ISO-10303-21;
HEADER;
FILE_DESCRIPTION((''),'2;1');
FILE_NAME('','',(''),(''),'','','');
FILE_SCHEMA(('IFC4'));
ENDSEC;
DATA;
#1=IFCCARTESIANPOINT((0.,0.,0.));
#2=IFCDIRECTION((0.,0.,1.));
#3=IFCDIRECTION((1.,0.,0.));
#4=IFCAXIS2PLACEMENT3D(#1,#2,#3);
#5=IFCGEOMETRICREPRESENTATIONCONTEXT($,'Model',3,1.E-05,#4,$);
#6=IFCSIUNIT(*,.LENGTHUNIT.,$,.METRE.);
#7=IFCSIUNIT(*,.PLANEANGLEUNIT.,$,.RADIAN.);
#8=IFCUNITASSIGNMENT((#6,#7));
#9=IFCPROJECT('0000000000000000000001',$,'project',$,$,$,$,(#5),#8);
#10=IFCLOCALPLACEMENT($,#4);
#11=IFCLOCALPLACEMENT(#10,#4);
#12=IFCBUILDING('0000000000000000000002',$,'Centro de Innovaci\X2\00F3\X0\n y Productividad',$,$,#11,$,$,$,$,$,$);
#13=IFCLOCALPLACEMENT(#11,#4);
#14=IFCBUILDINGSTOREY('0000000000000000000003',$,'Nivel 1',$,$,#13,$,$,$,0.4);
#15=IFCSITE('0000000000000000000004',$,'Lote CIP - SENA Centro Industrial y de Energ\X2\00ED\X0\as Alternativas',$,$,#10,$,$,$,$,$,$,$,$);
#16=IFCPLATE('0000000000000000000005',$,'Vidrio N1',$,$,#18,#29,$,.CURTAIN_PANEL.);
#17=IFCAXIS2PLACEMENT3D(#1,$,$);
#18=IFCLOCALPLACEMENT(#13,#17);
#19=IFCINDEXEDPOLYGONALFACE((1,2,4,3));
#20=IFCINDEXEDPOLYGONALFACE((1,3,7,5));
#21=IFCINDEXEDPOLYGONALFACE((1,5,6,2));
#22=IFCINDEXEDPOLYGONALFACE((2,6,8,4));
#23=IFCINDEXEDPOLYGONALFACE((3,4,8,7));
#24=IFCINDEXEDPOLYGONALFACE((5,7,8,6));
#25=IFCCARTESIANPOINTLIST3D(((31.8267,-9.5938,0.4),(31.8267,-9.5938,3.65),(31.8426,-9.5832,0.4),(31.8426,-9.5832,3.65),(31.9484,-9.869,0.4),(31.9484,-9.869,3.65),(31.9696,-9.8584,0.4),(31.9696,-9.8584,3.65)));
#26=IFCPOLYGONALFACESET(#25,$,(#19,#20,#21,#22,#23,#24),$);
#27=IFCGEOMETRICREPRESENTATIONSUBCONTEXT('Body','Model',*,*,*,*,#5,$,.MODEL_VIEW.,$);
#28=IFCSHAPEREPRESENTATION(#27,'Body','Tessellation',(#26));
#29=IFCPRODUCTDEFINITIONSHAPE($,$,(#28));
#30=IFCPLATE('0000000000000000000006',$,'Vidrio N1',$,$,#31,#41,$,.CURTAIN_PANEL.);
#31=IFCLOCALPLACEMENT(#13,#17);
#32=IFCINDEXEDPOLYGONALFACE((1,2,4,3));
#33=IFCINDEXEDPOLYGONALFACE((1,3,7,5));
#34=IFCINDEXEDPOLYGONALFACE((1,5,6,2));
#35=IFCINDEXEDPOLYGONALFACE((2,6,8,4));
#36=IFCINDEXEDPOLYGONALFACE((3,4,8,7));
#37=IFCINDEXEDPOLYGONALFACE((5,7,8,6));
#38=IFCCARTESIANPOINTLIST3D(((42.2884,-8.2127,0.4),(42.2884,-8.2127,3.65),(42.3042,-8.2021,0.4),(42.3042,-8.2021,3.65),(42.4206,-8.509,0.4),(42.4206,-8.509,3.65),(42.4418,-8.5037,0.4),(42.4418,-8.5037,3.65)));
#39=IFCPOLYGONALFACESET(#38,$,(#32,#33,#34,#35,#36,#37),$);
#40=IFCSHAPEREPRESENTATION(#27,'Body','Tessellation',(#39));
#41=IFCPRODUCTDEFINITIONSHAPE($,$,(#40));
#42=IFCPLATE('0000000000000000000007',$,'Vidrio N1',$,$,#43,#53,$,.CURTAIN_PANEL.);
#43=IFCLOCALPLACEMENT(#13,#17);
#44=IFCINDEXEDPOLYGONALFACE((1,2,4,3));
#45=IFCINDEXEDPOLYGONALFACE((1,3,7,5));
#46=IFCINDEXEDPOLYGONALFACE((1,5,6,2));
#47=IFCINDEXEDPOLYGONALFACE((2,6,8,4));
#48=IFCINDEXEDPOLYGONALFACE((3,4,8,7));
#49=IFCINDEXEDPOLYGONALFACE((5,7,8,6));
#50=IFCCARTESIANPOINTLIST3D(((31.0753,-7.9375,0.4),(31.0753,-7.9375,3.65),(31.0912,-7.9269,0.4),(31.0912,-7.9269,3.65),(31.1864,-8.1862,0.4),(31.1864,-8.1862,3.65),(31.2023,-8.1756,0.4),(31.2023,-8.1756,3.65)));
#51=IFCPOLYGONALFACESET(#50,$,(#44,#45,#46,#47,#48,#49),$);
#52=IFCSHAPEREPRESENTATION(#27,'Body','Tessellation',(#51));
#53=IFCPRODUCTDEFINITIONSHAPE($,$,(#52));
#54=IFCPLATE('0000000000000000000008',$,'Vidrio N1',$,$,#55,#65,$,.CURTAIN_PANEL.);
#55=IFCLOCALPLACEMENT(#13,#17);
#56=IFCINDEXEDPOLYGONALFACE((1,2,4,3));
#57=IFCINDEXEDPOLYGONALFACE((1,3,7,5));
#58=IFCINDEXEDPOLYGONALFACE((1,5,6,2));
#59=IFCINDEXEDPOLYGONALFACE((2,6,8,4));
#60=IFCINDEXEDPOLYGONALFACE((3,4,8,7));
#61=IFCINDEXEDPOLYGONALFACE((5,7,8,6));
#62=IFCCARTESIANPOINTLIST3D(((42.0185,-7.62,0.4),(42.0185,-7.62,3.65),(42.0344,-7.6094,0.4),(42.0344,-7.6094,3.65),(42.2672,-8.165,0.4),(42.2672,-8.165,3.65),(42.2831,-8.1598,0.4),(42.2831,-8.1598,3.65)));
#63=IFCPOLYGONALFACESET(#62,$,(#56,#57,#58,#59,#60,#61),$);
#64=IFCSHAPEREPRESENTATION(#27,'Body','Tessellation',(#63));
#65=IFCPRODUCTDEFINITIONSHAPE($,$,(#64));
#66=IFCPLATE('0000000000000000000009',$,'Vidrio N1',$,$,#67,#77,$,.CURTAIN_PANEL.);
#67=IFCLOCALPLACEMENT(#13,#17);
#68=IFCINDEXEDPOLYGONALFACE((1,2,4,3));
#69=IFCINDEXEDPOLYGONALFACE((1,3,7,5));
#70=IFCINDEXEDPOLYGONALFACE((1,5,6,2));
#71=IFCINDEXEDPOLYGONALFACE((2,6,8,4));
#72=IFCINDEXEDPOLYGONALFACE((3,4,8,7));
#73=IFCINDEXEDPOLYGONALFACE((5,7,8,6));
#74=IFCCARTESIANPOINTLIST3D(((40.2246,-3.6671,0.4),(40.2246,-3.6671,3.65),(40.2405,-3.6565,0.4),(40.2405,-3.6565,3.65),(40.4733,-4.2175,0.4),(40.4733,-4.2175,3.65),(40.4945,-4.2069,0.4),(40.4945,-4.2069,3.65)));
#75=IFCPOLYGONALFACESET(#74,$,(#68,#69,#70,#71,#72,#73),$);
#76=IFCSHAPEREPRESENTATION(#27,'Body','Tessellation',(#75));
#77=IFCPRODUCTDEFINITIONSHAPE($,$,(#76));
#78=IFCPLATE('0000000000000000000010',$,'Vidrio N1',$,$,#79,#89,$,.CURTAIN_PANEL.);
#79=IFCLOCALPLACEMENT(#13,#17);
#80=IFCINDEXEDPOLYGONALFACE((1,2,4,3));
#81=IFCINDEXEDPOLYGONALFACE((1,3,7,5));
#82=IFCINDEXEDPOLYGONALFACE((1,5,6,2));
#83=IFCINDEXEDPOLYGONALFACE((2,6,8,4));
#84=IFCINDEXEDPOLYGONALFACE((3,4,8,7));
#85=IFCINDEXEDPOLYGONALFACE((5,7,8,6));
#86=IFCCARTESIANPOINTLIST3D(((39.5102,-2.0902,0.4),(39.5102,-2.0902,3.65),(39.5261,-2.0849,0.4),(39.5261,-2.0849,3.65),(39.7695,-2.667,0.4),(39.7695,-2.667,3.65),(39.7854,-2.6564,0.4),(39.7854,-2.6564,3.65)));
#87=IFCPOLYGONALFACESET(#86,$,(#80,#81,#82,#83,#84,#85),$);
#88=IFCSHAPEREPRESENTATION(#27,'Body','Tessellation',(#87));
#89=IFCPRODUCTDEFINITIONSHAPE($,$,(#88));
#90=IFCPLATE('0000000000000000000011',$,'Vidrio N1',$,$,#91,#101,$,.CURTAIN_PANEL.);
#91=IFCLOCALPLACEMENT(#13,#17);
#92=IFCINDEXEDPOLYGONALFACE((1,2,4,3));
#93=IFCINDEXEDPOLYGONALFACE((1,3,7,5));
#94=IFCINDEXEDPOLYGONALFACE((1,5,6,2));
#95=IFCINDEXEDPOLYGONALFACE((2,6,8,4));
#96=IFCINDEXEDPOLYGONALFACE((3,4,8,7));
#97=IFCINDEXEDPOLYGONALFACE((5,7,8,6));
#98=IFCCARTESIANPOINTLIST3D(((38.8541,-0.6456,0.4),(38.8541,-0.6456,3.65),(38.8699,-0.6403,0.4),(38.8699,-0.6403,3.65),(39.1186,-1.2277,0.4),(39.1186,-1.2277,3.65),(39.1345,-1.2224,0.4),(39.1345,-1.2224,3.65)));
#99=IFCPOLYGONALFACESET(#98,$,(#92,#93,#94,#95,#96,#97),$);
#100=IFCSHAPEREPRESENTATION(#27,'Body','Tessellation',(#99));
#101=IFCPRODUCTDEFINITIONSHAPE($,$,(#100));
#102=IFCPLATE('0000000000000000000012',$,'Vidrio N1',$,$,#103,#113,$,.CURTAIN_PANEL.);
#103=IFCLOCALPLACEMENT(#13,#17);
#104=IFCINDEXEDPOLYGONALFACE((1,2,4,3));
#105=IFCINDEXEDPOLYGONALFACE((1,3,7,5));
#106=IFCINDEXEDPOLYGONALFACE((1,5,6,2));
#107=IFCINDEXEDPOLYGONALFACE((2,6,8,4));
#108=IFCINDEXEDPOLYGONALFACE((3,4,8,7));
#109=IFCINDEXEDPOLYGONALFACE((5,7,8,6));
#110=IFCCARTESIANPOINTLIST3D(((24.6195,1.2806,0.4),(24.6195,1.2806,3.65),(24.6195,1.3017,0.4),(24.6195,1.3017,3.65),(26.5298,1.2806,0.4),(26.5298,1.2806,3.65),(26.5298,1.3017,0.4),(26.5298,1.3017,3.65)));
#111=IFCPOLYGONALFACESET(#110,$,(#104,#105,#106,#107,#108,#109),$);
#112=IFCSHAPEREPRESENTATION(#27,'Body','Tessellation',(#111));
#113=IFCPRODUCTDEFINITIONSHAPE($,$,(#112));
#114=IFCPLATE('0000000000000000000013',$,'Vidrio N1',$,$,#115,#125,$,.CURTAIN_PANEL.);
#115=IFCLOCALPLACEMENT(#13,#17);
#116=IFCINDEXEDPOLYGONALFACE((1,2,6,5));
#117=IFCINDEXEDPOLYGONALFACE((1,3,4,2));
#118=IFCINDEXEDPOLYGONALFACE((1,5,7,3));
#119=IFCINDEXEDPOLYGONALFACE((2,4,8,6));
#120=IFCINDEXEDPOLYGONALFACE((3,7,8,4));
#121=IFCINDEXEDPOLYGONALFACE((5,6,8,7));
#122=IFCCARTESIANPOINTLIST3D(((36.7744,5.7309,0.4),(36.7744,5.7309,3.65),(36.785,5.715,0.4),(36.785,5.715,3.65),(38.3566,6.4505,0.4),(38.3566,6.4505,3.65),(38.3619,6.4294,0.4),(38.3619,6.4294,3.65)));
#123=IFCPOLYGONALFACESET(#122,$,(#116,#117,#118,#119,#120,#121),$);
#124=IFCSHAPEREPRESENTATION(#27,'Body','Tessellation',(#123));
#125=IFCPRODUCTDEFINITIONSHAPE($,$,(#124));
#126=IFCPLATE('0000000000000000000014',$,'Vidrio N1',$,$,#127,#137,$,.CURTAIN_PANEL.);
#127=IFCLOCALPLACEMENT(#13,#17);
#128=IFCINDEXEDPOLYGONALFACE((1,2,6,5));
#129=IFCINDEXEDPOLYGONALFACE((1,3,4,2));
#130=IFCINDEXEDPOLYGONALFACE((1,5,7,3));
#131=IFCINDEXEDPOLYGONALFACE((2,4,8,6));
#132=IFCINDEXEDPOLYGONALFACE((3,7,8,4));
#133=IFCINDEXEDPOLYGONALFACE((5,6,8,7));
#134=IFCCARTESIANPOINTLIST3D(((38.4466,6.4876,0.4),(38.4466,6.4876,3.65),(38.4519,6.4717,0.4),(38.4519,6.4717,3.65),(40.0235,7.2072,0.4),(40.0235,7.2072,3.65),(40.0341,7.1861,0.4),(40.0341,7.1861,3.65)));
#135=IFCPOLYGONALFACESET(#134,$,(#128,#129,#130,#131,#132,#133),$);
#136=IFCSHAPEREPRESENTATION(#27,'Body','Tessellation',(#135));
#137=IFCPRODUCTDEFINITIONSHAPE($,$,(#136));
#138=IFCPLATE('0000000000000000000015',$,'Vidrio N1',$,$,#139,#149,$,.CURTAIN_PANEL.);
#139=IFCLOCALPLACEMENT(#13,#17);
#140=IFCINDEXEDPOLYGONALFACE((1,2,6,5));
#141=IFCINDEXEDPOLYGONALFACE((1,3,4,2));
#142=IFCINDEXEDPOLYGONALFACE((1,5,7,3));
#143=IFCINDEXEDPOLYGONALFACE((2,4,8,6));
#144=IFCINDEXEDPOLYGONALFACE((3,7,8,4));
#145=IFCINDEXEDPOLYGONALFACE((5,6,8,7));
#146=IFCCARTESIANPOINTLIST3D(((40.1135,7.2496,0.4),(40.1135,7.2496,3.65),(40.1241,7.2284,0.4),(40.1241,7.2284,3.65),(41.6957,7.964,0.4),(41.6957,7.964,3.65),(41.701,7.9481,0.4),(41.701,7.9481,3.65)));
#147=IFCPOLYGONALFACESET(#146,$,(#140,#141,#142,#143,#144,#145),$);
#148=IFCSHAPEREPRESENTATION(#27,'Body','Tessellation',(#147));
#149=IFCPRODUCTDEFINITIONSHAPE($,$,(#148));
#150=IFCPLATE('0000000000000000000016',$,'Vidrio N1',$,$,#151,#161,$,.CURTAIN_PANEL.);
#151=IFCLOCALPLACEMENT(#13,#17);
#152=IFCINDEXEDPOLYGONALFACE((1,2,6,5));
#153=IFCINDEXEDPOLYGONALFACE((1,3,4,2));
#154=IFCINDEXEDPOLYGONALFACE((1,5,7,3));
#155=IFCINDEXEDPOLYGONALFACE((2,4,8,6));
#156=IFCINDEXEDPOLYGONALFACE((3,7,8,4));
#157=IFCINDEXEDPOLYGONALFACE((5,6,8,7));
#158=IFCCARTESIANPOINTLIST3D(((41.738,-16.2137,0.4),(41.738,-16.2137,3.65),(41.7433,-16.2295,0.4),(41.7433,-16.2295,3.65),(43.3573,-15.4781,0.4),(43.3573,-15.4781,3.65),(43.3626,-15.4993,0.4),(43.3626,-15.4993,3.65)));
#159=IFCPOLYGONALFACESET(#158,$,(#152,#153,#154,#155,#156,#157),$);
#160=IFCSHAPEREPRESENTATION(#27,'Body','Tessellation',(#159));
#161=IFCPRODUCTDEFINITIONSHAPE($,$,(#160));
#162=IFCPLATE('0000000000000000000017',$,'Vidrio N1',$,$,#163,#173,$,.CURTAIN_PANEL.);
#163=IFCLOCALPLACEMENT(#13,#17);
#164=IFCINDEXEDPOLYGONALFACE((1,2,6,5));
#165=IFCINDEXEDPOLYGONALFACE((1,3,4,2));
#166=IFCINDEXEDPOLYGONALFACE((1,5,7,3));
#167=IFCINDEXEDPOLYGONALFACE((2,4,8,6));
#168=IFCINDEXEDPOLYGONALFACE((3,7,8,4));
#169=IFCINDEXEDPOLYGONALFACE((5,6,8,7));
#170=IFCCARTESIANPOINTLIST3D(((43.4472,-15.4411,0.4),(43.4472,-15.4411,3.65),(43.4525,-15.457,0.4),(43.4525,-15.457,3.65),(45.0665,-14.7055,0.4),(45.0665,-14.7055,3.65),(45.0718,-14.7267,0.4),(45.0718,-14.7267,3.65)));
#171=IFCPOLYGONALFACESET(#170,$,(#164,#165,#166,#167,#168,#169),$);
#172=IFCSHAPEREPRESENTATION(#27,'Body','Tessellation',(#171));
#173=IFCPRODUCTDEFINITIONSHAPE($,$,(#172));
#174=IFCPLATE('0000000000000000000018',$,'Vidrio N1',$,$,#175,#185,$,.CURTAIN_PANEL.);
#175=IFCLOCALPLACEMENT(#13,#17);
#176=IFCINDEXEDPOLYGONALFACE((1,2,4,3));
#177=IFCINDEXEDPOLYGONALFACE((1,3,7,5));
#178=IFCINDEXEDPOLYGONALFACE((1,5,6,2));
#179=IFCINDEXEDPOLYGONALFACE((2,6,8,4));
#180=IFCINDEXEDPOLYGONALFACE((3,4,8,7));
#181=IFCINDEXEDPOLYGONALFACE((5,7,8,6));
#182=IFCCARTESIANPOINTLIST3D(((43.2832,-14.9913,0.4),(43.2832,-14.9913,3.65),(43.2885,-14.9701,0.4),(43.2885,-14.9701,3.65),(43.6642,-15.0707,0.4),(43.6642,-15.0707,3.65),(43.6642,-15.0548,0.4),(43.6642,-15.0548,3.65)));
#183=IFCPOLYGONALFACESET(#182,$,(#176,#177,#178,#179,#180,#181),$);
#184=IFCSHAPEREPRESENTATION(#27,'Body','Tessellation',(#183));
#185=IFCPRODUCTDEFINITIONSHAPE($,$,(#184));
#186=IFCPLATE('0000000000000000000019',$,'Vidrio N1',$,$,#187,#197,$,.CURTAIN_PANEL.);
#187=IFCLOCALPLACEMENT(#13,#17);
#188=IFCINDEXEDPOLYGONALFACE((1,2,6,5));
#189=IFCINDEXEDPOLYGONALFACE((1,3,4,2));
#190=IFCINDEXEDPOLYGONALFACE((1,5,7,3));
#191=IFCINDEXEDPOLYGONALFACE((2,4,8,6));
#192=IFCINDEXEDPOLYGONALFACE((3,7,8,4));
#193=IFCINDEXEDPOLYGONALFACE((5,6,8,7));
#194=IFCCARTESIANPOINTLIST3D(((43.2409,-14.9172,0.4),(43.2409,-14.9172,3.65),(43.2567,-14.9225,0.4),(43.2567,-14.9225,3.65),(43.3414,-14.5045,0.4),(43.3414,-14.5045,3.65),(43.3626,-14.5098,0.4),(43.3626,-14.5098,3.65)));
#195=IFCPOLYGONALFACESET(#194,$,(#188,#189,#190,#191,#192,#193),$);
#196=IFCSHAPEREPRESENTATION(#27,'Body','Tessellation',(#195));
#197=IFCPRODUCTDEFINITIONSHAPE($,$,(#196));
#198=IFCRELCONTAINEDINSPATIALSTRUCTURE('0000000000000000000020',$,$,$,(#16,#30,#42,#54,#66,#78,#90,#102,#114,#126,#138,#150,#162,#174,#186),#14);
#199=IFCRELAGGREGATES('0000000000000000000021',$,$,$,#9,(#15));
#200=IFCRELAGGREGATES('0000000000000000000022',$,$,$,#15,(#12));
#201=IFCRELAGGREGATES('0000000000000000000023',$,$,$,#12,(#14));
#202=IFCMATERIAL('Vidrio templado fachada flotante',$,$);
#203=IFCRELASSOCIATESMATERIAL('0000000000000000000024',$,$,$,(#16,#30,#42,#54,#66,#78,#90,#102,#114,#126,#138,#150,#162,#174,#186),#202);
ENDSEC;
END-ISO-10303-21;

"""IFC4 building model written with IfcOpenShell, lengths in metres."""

from ifc_helpers import new_model, si_unit, frame, origin_with_axes, place, context, subcontext, project, spatial, polyline, outline, extrude, material, element, save


model = new_model("IFC4")

# Units and contexts
model_context = context("Model", 3, precision=1e-05, world=origin_with_axes())
body_context = subcontext(model_context, "Body", "Model", "MODEL_VIEW")
ifc_project = project(units=[si_unit("LENGTHUNIT", "METRE"), si_unit("PLANEANGLEUNIT", "RADIAN")], contexts=[model_context])

# Site, building, storey
site_placement = place(None, origin_with_axes())
site = spatial("IfcSite", under=ifc_project, at=site_placement, Name="Lote CIP - SENA Centro Industrial y de Energías Alternativas")
building_placement = place(site_placement, origin_with_axes())
building = spatial("IfcBuilding", under=site, at=building_placement, Name="Centro de Innovación y Productividad")
storey_placement = place(building_placement, origin_with_axes())
storey = spatial("IfcBuildingStorey", under=building, at=storey_placement, Name="Nivel 1", Elevation=0.4)

# Plates
ifc_material = material(Name="Vidrio templado fachada flotante")
plate_1_placement = place(storey_placement, origin_with_axes())
element("IfcPlate", 1, at=plate_1_placement, inside=storey, material=ifc_material, Name="Vidrio N1", PredefinedType="CURTAIN_PANEL", context=body_context, shape_type="SweptSolid", body=[
    extrude(outline(polyline([(31.8267, -9.5938), (31.8426, -9.5832), (31.9696, -9.8584), (31.9484, -9.869), (31.8267, -9.5938)])), frame((0.0, 0.0, 0.4)), (0.0, 0.0, 1.0), 3.25),
])
plate_2_placement = place(storey_placement, origin_with_axes())
element("IfcPlate", 2, at=plate_2_placement, inside=storey, material=ifc_material, Name="Vidrio N1", PredefinedType="CURTAIN_PANEL", context=body_context, shape_type="SweptSolid", body=[
    extrude(outline(polyline([(42.4206, -8.509), (42.2884, -8.2127), (42.3042, -8.2021), (42.4418, -8.5037), (42.4206, -8.509)])), frame((0.0, 0.0, 0.4)), (0.0, 0.0, 1.0), 3.25),
])
plate_3_placement = place(storey_placement, origin_with_axes())
element("IfcPlate", 3, at=plate_3_placement, inside=storey, material=ifc_material, Name="Vidrio N1", PredefinedType="CURTAIN_PANEL", context=body_context, shape_type="SweptSolid", body=[
    extrude(outline(polyline([(31.1864, -8.1862), (31.0753, -7.9375), (31.0912, -7.9269), (31.2023, -8.1756), (31.1864, -8.1862)])), frame((0.0, 0.0, 0.4)), (0.0, 0.0, 1.0), 3.25),
])
plate_4_placement = place(storey_placement, origin_with_axes())
element("IfcPlate", 4, at=plate_4_placement, inside=storey, material=ifc_material, Name="Vidrio N1", PredefinedType="CURTAIN_PANEL", context=body_context, shape_type="SweptSolid", body=[
    extrude(outline(polyline([(42.0185, -7.62), (42.0344, -7.6094), (42.2831, -8.1598), (42.2672, -8.165), (42.0185, -7.62)])), frame((0.0, 0.0, 0.4)), (0.0, 0.0, 1.0), 3.25),
])
plate_5_placement = place(storey_placement, origin_with_axes())
element("IfcPlate", 5, at=plate_5_placement, inside=storey, material=ifc_material, Name="Vidrio N1", PredefinedType="CURTAIN_PANEL", context=body_context, shape_type="SweptSolid", body=[
    extrude(outline(polyline([(40.2405, -3.6565), (40.4945, -4.2069), (40.4733, -4.2175), (40.2246, -3.6671), (40.2405, -3.6565)])), frame((0.0, 0.0, 0.4)), (0.0, 0.0, 1.0), 3.25),
])
plate_6_placement = place(storey_placement, origin_with_axes())
element("IfcPlate", 6, at=plate_6_placement, inside=storey, material=ifc_material, Name="Vidrio N1", PredefinedType="CURTAIN_PANEL", context=body_context, shape_type="SweptSolid", body=[
    extrude(outline(polyline([(39.7854, -2.6564), (39.7695, -2.667), (39.5102, -2.0902), (39.5261, -2.0849), (39.7854, -2.6564)])), frame((0.0, 0.0, 0.4)), (0.0, 0.0, 1.0), 3.25),
])
plate_7_placement = place(storey_placement, origin_with_axes())
element("IfcPlate", 7, at=plate_7_placement, inside=storey, material=ifc_material, Name="Vidrio N1", PredefinedType="CURTAIN_PANEL", context=body_context, shape_type="SweptSolid", body=[
    extrude(outline(polyline([(38.8541, -0.6456), (38.8699, -0.6403), (39.1345, -1.2224), (39.1186, -1.2277), (38.8541, -0.6456)])), frame((0.0, 0.0, 0.4)), (0.0, 0.0, 1.0), 3.25),
])
plate_8_placement = place(storey_placement, origin_with_axes())
element("IfcPlate", 8, at=plate_8_placement, inside=storey, material=ifc_material, Name="Vidrio N1", PredefinedType="CURTAIN_PANEL", context=body_context, shape_type="SweptSolid", body=[
    extrude(outline(polyline([(24.6195, 1.2806), (24.6195, 1.3017), (26.5298, 1.3017), (26.5298, 1.2806), (24.6195, 1.2806)])), frame((0.0, 0.0, 0.4)), (0.0, 0.0, 1.0), 3.25),
])
plate_9_placement = place(storey_placement, origin_with_axes())
element("IfcPlate", 9, at=plate_9_placement, inside=storey, material=ifc_material, Name="Vidrio N1", PredefinedType="CURTAIN_PANEL", context=body_context, shape_type="SweptSolid", body=[
    extrude(outline(polyline([(38.3566, 6.4505), (38.3619, 6.4294), (36.785, 5.715), (36.7744, 5.7309), (38.3566, 6.4505)])), frame((0.0, 0.0, 0.4)), (0.0, 0.0, 1.0), 3.25),
])
plate_10_placement = place(storey_placement, origin_with_axes())
element("IfcPlate", 10, at=plate_10_placement, inside=storey, material=ifc_material, Name="Vidrio N1", PredefinedType="CURTAIN_PANEL", context=body_context, shape_type="SweptSolid", body=[
    extrude(outline(polyline([(38.4466, 6.4876), (40.0235, 7.2072), (40.0341, 7.1861), (38.4519, 6.4717), (38.4466, 6.4876)])), frame((0.0, 0.0, 0.4)), (0.0, 0.0, 1.0), 3.25),
])
plate_11_placement = place(storey_placement, origin_with_axes())
element("IfcPlate", 11, at=plate_11_placement, inside=storey, material=ifc_material, Name="Vidrio N1", PredefinedType="CURTAIN_PANEL", context=body_context, shape_type="SweptSolid", body=[
    extrude(outline(polyline([(40.1135, 7.2496), (41.6957, 7.964), (41.701, 7.9481), (40.1241, 7.2284), (40.1135, 7.2496)])), frame((0.0, 0.0, 0.4)), (0.0, 0.0, 1.0), 3.25),
])
plate_12_placement = place(storey_placement, origin_with_axes())
element("IfcPlate", 12, at=plate_12_placement, inside=storey, material=ifc_material, Name="Vidrio N1", PredefinedType="CURTAIN_PANEL", context=body_context, shape_type="SweptSolid", body=[
    extrude(outline(polyline([(41.7433, -16.2295), (41.738, -16.2137), (43.3573, -15.4781), (43.3626, -15.4993), (41.7433, -16.2295)])), frame((0.0, 0.0, 0.4)), (0.0, 0.0, 1.0), 3.25),
])
plate_13_placement = place(storey_placement, origin_with_axes())
element("IfcPlate", 13, at=plate_13_placement, inside=storey, material=ifc_material, Name="Vidrio N1", PredefinedType="CURTAIN_PANEL", context=body_context, shape_type="SweptSolid", body=[
    extrude(outline(polyline([(45.0718, -14.7267), (43.4525, -15.457), (43.4472, -15.4411), (45.0665, -14.7055), (45.0718, -14.7267)])), frame((0.0, 0.0, 0.4)), (0.0, 0.0, 1.0), 3.25),
])
plate_14_placement = place(storey_placement, origin_with_axes())
element("IfcPlate", 14, at=plate_14_placement, inside=storey, material=ifc_material, Name="Vidrio N1", PredefinedType="CURTAIN_PANEL", context=body_context, shape_type="SweptSolid", body=[
    extrude(outline(polyline([(43.2885, -14.9701), (43.6642, -15.0548), (43.6642, -15.0707), (43.2832, -14.9913), (43.2885, -14.9701)])), frame((0.0, 0.0, 0.4)), (0.0, 0.0, 1.0), 3.25),
])
plate_15_placement = place(storey_placement, origin_with_axes())
element("IfcPlate", 15, at=plate_15_placement, inside=storey, material=ifc_material, Name="Vidrio N1", PredefinedType="CURTAIN_PANEL", context=body_context, shape_type="SweptSolid", body=[
    extrude(outline(polyline([(43.2567, -14.9225), (43.2409, -14.9172), (43.3414, -14.5045), (43.3626, -14.5098), (43.2567, -14.9225)])), frame((0.0, 0.0, 0.4)), (0.0, 0.0, 1.0), 3.25),
])

save(model, "model.ifc")
